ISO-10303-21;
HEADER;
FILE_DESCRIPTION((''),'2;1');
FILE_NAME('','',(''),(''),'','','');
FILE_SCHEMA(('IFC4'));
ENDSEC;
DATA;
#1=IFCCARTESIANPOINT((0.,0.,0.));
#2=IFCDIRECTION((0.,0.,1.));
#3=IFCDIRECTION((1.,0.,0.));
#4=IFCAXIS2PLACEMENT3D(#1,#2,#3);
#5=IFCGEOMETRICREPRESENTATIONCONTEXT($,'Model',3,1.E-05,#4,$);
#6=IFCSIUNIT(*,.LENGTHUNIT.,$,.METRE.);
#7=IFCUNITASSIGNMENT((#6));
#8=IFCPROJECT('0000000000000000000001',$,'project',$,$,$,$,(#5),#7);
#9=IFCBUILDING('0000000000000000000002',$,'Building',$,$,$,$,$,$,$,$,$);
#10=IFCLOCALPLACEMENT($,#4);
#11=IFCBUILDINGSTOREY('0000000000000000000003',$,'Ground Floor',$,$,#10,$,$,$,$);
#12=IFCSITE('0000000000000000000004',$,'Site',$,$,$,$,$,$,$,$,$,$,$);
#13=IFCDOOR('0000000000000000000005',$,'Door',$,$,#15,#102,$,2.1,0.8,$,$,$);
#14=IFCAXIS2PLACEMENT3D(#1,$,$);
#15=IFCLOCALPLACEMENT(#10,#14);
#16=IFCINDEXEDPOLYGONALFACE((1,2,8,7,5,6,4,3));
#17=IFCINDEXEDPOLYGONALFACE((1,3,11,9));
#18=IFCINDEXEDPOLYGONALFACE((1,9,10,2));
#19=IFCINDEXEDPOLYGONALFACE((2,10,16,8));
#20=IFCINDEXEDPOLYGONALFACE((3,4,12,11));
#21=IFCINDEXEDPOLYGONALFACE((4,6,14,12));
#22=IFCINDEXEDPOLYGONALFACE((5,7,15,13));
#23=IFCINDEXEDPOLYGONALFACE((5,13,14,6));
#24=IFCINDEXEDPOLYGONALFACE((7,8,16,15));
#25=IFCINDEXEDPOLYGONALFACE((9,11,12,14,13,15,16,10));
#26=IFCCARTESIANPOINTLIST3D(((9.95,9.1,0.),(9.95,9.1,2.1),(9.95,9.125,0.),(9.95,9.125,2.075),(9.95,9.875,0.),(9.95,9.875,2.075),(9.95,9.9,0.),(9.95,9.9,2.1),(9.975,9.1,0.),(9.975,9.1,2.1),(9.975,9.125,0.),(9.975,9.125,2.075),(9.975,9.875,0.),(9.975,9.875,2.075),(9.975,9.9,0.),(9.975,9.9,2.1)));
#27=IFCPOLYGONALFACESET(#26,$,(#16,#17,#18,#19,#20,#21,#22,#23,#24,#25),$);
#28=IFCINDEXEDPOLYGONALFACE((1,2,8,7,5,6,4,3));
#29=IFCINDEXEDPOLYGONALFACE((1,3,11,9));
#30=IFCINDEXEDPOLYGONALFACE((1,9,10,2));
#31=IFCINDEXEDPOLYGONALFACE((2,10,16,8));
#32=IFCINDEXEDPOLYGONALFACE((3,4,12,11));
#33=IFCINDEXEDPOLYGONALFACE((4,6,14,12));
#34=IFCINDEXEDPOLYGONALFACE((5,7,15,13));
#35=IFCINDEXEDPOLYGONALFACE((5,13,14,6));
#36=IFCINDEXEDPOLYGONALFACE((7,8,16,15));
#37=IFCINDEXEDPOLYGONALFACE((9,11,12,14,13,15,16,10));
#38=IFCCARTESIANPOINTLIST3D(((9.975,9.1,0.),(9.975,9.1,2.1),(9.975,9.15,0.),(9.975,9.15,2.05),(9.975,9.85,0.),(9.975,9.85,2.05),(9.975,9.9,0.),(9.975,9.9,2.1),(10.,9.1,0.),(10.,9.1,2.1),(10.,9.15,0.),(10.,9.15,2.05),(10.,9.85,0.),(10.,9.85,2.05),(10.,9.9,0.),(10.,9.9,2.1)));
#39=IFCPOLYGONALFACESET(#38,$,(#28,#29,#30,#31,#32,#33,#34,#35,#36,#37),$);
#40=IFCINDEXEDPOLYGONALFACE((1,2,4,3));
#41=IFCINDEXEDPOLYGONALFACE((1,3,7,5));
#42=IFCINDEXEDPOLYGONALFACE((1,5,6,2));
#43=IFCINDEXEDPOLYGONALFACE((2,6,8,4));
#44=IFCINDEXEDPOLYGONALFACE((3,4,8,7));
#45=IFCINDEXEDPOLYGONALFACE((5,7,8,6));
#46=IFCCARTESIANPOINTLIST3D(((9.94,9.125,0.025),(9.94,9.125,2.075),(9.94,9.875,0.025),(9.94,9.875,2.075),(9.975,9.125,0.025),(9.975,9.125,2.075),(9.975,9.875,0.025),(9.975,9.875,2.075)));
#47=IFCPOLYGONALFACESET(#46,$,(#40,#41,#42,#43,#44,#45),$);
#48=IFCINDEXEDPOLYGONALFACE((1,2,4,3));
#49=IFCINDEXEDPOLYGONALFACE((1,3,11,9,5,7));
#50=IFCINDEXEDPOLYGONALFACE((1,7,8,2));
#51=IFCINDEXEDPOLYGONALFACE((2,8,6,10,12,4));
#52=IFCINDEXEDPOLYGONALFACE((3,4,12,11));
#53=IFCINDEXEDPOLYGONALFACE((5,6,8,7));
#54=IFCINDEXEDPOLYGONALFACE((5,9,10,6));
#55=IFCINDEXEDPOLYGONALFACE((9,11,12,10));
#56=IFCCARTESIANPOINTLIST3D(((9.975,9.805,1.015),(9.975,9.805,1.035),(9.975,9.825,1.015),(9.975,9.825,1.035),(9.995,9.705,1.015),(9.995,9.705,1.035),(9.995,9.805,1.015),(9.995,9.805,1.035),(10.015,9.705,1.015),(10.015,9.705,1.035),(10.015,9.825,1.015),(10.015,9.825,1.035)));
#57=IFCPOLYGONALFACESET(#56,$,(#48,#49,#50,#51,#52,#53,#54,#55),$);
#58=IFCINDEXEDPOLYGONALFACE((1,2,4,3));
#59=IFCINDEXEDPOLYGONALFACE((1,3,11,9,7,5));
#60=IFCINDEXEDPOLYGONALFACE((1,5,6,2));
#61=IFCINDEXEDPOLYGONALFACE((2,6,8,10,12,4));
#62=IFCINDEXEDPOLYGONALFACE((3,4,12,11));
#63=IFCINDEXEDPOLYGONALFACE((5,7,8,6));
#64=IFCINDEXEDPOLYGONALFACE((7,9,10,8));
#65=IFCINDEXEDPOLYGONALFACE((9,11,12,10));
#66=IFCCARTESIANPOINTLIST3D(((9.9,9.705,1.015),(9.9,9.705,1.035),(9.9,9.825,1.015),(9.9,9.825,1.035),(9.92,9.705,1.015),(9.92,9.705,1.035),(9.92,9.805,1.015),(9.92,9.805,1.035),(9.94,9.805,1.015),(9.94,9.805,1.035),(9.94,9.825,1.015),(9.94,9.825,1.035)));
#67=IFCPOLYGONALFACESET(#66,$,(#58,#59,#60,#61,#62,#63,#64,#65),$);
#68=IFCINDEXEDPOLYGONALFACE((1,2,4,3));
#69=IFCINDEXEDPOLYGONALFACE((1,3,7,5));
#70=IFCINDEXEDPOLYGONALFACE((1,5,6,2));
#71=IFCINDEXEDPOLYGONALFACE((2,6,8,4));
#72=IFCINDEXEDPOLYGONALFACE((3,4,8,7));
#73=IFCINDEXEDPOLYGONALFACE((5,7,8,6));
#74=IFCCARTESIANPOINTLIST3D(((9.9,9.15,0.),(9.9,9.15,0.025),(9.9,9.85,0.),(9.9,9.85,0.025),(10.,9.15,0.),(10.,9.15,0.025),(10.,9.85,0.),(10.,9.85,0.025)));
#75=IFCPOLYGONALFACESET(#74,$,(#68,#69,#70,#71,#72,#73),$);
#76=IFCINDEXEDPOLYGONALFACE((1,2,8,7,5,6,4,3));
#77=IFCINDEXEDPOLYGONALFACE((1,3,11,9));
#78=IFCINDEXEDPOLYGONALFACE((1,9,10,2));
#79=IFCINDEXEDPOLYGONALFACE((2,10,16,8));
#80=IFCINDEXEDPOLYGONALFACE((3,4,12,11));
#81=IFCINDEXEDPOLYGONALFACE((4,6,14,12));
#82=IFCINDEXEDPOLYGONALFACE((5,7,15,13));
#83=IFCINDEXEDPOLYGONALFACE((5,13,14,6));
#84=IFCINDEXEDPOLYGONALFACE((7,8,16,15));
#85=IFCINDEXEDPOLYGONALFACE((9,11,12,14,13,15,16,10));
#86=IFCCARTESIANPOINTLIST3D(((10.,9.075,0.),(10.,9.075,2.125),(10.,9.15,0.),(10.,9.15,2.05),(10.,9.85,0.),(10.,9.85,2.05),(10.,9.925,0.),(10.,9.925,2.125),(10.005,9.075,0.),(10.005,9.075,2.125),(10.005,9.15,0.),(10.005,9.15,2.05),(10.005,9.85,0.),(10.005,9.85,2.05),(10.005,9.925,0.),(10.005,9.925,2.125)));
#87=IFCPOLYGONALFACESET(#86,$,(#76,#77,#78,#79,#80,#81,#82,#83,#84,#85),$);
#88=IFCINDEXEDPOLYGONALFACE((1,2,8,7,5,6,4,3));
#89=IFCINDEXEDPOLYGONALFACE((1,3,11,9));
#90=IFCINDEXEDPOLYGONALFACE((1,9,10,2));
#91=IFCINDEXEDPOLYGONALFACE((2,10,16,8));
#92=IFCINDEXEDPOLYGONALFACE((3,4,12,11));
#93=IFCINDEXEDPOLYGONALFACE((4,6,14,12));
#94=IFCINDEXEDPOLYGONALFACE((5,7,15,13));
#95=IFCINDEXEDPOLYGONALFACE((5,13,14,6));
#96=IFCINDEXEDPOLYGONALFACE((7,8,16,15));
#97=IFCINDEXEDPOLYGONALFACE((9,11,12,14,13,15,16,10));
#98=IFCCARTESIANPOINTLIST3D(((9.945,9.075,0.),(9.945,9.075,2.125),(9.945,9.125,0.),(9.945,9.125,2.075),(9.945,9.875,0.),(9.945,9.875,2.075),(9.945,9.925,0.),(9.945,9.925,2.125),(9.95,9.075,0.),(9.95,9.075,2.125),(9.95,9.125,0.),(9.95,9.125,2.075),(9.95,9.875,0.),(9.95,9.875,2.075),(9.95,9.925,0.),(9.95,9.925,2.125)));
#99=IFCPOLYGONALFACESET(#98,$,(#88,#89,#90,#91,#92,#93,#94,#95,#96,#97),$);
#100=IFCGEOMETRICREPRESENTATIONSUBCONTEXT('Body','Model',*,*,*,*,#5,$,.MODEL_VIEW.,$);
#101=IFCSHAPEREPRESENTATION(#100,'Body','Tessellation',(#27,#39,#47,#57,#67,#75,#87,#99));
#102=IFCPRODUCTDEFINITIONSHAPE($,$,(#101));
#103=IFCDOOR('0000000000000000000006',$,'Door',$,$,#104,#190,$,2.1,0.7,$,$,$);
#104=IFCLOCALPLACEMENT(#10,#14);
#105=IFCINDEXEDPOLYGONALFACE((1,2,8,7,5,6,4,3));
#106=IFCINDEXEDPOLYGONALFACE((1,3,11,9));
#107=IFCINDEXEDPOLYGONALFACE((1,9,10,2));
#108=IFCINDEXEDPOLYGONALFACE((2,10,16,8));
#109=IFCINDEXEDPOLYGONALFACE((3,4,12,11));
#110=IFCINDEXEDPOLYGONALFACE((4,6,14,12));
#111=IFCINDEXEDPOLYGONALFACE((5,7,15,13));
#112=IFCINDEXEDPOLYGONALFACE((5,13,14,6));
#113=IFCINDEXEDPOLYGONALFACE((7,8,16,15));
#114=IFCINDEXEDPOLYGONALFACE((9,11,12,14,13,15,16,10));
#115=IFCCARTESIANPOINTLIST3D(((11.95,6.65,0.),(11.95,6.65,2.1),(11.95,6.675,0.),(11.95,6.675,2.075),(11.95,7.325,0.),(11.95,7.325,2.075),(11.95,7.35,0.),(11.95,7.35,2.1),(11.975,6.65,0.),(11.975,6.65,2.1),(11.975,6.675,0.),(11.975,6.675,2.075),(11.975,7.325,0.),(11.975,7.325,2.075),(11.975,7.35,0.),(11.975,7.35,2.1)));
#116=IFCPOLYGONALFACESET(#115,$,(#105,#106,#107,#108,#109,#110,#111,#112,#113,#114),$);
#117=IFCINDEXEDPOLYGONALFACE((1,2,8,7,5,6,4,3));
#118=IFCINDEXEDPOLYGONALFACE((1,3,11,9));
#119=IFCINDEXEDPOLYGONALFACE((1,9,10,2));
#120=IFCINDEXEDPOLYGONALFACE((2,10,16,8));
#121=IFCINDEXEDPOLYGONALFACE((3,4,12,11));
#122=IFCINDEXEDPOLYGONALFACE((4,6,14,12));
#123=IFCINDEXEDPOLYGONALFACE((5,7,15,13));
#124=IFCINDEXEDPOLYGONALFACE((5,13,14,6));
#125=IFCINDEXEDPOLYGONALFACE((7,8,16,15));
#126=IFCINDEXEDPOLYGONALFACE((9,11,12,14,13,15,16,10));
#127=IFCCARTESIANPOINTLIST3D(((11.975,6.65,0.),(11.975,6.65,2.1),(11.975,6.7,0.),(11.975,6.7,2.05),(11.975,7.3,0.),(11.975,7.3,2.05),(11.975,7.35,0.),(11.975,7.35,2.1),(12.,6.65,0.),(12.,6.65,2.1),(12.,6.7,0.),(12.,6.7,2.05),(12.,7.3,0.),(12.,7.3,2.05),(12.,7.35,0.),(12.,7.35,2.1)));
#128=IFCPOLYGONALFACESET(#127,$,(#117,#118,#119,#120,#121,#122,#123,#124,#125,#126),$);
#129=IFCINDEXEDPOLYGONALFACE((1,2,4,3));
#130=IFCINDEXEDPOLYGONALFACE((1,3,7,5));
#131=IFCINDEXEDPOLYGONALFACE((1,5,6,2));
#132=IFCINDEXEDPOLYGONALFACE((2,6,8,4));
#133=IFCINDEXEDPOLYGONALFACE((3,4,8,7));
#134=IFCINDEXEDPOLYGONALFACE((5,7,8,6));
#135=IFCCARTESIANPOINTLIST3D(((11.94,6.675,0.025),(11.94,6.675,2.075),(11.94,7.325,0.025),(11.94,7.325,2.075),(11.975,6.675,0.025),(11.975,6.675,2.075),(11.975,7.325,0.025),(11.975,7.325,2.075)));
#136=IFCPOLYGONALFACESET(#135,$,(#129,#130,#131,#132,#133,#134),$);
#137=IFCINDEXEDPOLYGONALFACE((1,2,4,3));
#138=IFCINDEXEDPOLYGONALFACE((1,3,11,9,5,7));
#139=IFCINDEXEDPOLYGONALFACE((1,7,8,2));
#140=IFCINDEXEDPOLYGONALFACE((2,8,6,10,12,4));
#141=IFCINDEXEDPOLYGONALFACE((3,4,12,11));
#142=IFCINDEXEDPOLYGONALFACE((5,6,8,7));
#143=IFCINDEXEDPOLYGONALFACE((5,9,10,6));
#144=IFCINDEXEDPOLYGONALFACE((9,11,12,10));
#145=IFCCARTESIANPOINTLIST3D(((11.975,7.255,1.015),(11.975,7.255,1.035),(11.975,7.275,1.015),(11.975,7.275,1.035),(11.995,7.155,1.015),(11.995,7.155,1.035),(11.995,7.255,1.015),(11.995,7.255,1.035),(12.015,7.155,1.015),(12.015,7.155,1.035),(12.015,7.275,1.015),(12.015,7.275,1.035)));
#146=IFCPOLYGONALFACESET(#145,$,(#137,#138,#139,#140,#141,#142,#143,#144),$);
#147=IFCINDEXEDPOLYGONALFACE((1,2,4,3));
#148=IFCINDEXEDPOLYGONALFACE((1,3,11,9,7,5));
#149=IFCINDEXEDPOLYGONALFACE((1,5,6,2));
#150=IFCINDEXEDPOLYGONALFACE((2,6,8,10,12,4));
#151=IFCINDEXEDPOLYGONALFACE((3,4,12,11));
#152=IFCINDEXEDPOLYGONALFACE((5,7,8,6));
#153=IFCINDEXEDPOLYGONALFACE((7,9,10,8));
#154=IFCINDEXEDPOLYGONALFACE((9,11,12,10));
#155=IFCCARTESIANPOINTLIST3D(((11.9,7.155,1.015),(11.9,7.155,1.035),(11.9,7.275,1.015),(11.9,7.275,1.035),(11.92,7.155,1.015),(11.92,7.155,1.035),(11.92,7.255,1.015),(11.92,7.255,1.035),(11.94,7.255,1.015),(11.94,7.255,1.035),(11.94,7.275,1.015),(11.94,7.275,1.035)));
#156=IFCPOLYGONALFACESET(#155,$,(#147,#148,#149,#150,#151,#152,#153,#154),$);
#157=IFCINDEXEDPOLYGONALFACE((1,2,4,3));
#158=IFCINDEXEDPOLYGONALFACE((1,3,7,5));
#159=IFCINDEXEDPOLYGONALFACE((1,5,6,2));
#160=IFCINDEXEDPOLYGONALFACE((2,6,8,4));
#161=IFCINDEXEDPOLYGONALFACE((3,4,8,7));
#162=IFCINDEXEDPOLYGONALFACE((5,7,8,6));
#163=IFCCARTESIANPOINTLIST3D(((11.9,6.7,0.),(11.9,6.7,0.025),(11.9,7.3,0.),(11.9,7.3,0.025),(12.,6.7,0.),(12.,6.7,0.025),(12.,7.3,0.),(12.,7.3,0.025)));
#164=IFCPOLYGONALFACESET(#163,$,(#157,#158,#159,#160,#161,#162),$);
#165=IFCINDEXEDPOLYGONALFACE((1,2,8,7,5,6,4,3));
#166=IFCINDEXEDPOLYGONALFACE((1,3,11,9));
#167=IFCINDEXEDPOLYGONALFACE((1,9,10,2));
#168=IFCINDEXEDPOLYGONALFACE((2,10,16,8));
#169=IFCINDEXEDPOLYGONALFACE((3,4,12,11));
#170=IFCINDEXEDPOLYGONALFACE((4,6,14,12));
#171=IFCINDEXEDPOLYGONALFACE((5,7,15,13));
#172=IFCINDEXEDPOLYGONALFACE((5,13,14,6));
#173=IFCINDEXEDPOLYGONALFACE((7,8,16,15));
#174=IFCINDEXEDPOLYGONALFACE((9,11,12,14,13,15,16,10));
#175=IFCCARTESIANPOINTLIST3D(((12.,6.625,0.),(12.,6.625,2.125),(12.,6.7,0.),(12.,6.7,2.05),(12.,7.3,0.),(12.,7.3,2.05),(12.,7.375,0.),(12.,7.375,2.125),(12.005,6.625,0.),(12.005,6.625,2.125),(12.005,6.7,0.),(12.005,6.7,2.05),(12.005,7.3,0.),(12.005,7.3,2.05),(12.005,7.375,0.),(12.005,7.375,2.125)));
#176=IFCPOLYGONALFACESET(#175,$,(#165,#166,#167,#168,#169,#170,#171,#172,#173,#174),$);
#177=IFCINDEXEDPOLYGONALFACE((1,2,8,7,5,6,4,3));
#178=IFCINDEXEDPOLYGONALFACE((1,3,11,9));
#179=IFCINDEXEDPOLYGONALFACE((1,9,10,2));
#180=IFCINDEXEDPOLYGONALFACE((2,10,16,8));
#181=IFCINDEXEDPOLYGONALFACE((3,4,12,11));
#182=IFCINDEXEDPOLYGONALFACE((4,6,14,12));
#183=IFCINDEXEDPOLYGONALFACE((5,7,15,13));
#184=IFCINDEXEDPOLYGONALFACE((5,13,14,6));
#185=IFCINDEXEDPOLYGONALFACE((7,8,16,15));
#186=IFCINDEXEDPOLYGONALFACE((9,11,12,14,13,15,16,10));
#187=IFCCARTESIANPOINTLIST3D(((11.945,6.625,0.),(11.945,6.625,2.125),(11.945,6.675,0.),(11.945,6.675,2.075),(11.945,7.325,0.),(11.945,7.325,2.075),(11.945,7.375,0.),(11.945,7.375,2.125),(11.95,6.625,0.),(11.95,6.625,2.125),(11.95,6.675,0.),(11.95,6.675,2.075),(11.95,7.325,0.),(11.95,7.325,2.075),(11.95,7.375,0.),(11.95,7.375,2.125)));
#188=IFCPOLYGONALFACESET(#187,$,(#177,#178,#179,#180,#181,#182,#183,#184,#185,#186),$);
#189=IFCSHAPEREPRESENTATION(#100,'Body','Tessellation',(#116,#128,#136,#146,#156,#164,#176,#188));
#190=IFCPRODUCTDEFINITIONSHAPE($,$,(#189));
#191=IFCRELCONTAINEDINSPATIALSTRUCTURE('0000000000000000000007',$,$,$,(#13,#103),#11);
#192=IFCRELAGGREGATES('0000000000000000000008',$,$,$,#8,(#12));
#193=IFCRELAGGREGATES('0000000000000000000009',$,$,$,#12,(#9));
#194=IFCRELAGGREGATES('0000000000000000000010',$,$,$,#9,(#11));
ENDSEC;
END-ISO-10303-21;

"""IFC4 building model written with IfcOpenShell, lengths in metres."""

from ifc_helpers import new_model, si_unit, frame, origin_with_axes, place, context, subcontext, project, spatial, line, indexed_curve, outline, extrude, element, save


model = new_model("IFC4")

# Units and contexts
model_context = context("Model", 3, precision=1e-05, world=origin_with_axes())
body_context = subcontext(model_context, "Body", "Model", "MODEL_VIEW")
ifc_project = project(units=[si_unit("LENGTHUNIT", "METRE")], contexts=[model_context])

# Site, building, storey
site = spatial("IfcSite", under=ifc_project, Name="Site")
building = spatial("IfcBuilding", under=site, Name="Building")
storey_placement = place(None, origin_with_axes())
storey = spatial("IfcBuildingStorey", under=building, at=storey_placement, Name="Ground Floor")

# Doors
door_1_placement = place(storey_placement, frame((10.0, 9.1, 0.0), z_axis=(0.0, 0.0, 1.0), x_axis=(0.0, 1.0, 0.0)))
element("IfcDoor", 1, at=door_1_placement, inside=storey, Name="Door", OverallHeight=2.1, OverallWidth=0.8, context=body_context, shape_type="SweptSolid", body=[
    extrude(outline(indexed_curve([(0.0, 0.0), (0.0, 2.1), (0.8, 2.1), (0.8, 0.0), (0.775, 0.0), (0.775, 2.075), (0.025, 2.075), (0.025, 0.0)], segments=[line(1, 2, 3, 4, 5, 6, 7, 8, 1)])), frame((0.0, 0.025, 0.0), z_axis=(0.0, -1.0, 0.0), x_axis=(1.0, 0.0, 0.0)), (0.0, 0.0, -1.0), 0.025),
    extrude(outline(indexed_curve([(0.0, 0.0), (0.0, 2.1), (0.8, 2.1), (0.8, 0.0), (0.75, 0.0), (0.75, 2.05), (0.05, 2.05), (0.05, 0.0)], segments=[line(1, 2, 3, 4, 5, 6, 7, 8, 1)])), frame((0.0, 0.0, 0.0), z_axis=(0.0, -1.0, 0.0), x_axis=(1.0, 0.0, 0.0)), (0.0, 0.0, -1.0), 0.025),
    extrude(outline(indexed_curve([(0.0, 0.0), (0.75, 0.0), (0.75, 0.035), (0.0, 0.035)], segments=[line(1, 2, 3, 4, 1)])), frame((0.025, 0.025, 0.025), z_axis=(0.0, 0.0, 1.0), x_axis=(1.0, 0.0, 0.0)), (0.0, 0.0, 1.0), 2.05),
    extrude(outline(indexed_curve([(0.0, 0.0), (0.0, -0.04), (-0.12, -0.04), (-0.12, -0.02), (-0.02, -0.02), (-0.02, 0.0)], segments=[line(1, 2, 3, 4, 5, 6, 1)])), frame((0.725, 0.025, 1.015), z_axis=(0.0, 0.0, 1.0), x_axis=(1.0, 0.0, 0.0)), (0.0, 0.0, 1.0), 0.02),
    extrude(outline(indexed_curve([(0.0, 0.0), (0.0, 0.04), (-0.12, 0.04), (-0.12, 0.02), (-0.02, 0.02), (-0.02, 0.0)], segments=[line(1, 2, 3, 4, 5, 6, 1)])), frame((0.725, 0.06, 1.015), z_axis=(0.0, 0.0, 1.0), x_axis=(1.0, 0.0, 0.0)), (0.0, 0.0, 1.0), 0.02),
    extrude(outline(indexed_curve([(0.0, 0.0), (0.7, 0.0), (0.7, 0.1), (0.0, 0.1)], segments=[line(1, 2, 3, 4, 1)])), frame((0.05, 0.0, 0.0), z_axis=(0.0, 0.0, 1.0), x_axis=(1.0, 0.0, 0.0)), (0.0, 0.0, 1.0), 0.025),
    extrude(outline(indexed_curve([(0.0, 0.0), (0.0, 2.125), (0.85, 2.125), (0.85, 0.0), (0.775, 0.0), (0.775, 2.05), (0.075, 2.05), (0.075, 0.0)], segments=[line(1, 2, 3, 4, 5, 6, 7, 8, 1)])), frame((-0.025, -0.005, 0.0), z_axis=(0.0, -1.0, 0.0), x_axis=(1.0, 0.0, 0.0)), (0.0, 0.0, -1.0), 0.005),
    extrude(outline(indexed_curve([(0.0, 0.0), (0.0, 2.125), (0.85, 2.125), (0.85, 0.0), (0.8, 0.0), (0.8, 2.075), (0.05, 2.075), (0.05, 0.0)], segments=[line(1, 2, 3, 4, 5, 6, 7, 8, 1)])), frame((-0.025, 0.05, 0.0), z_axis=(0.0, -1.0, 0.0), x_axis=(1.0, 0.0, 0.0)), (0.0, 0.0, -1.0), 0.005),
])
door_2_placement = place(storey_placement, frame((12.0, 6.65, 0.0), z_axis=(0.0, 0.0, 1.0), x_axis=(0.0, 1.0, 0.0)))
element("IfcDoor", 2, at=door_2_placement, inside=storey, Name="Door", OverallHeight=2.1, OverallWidth=0.7, context=body_context, shape_type="SweptSolid", body=[
    extrude(outline(indexed_curve([(0.0, 0.0), (0.0, 2.1), (0.7, 2.1), (0.7, 0.0), (0.675, 0.0), (0.675, 2.075), (0.025, 2.075), (0.025, 0.0)], segments=[line(1, 2, 3, 4, 5, 6, 7, 8, 1)])), frame((0.0, 0.025, 0.0), z_axis=(0.0, -1.0, 0.0), x_axis=(1.0, 0.0, 0.0)), (0.0, 0.0, -1.0), 0.025),
    extrude(outline(indexed_curve([(0.0, 0.0), (0.0, 2.1), (0.7, 2.1), (0.7, 0.0), (0.65, 0.0), (0.65, 2.05), (0.05, 2.05), (0.05, 0.0)], segments=[line(1, 2, 3, 4, 5, 6, 7, 8, 1)])), frame((0.0, 0.0, 0.0), z_axis=(0.0, -1.0, 0.0), x_axis=(1.0, 0.0, 0.0)), (0.0, 0.0, -1.0), 0.025),
    extrude(outline(indexed_curve([(0.0, 0.0), (0.65, 0.0), (0.65, 0.035), (0.0, 0.035)], segments=[line(1, 2, 3, 4, 1)])), frame((0.025, 0.025, 0.025), z_axis=(0.0, 0.0, 1.0), x_axis=(1.0, 0.0, 0.0)), (0.0, 0.0, 1.0), 2.05),
    extrude(outline(indexed_curve([(0.0, 0.0), (0.0, -0.04), (-0.12, -0.04), (-0.12, -0.02), (-0.02, -0.02), (-0.02, 0.0)], segments=[line(1, 2, 3, 4, 5, 6, 1)])), frame((0.625, 0.025, 1.015), z_axis=(0.0, 0.0, 1.0), x_axis=(1.0, 0.0, 0.0)), (0.0, 0.0, 1.0), 0.02),
    extrude(outline(indexed_curve([(0.0, 0.0), (0.0, 0.04), (-0.12, 0.04), (-0.12, 0.02), (-0.02, 0.02), (-0.02, 0.0)], segments=[line(1, 2, 3, 4, 5, 6, 1)])), frame((0.625, 0.06, 1.015), z_axis=(0.0, 0.0, 1.0), x_axis=(1.0, 0.0, 0.0)), (0.0, 0.0, 1.0), 0.02),
    extrude(outline(indexed_curve([(0.0, 0.0), (0.6, 0.0), (0.6, 0.1), (0.0, 0.1)], segments=[line(1, 2, 3, 4, 1)])), frame((0.05, 0.0, 0.0), z_axis=(0.0, 0.0, 1.0), x_axis=(1.0, 0.0, 0.0)), (0.0, 0.0, 1.0), 0.025),
    extrude(outline(indexed_curve([(0.0, 0.0), (0.0, 2.125), (0.75, 2.125), (0.75, 0.0), (0.675, 0.0), (0.675, 2.05), (0.075, 2.05), (0.075, 0.0)], segments=[line(1, 2, 3, 4, 5, 6, 7, 8, 1)])), frame((-0.025, -0.005, 0.0), z_axis=(0.0, -1.0, 0.0), x_axis=(1.0, 0.0, 0.0)), (0.0, 0.0, -1.0), 0.005),
    extrude(outline(indexed_curve([(0.0, 0.0), (0.0, 2.125), (0.75, 2.125), (0.75, 0.0), (0.7, 0.0), (0.7, 2.075), (0.05, 2.075), (0.05, 0.0)], segments=[line(1, 2, 3, 4, 5, 6, 7, 8, 1)])), frame((-0.025, 0.05, 0.0), z_axis=(0.0, -1.0, 0.0), x_axis=(1.0, 0.0, 0.0)), (0.0, 0.0, -1.0), 0.005),
])

save(model, "model.ifc")
